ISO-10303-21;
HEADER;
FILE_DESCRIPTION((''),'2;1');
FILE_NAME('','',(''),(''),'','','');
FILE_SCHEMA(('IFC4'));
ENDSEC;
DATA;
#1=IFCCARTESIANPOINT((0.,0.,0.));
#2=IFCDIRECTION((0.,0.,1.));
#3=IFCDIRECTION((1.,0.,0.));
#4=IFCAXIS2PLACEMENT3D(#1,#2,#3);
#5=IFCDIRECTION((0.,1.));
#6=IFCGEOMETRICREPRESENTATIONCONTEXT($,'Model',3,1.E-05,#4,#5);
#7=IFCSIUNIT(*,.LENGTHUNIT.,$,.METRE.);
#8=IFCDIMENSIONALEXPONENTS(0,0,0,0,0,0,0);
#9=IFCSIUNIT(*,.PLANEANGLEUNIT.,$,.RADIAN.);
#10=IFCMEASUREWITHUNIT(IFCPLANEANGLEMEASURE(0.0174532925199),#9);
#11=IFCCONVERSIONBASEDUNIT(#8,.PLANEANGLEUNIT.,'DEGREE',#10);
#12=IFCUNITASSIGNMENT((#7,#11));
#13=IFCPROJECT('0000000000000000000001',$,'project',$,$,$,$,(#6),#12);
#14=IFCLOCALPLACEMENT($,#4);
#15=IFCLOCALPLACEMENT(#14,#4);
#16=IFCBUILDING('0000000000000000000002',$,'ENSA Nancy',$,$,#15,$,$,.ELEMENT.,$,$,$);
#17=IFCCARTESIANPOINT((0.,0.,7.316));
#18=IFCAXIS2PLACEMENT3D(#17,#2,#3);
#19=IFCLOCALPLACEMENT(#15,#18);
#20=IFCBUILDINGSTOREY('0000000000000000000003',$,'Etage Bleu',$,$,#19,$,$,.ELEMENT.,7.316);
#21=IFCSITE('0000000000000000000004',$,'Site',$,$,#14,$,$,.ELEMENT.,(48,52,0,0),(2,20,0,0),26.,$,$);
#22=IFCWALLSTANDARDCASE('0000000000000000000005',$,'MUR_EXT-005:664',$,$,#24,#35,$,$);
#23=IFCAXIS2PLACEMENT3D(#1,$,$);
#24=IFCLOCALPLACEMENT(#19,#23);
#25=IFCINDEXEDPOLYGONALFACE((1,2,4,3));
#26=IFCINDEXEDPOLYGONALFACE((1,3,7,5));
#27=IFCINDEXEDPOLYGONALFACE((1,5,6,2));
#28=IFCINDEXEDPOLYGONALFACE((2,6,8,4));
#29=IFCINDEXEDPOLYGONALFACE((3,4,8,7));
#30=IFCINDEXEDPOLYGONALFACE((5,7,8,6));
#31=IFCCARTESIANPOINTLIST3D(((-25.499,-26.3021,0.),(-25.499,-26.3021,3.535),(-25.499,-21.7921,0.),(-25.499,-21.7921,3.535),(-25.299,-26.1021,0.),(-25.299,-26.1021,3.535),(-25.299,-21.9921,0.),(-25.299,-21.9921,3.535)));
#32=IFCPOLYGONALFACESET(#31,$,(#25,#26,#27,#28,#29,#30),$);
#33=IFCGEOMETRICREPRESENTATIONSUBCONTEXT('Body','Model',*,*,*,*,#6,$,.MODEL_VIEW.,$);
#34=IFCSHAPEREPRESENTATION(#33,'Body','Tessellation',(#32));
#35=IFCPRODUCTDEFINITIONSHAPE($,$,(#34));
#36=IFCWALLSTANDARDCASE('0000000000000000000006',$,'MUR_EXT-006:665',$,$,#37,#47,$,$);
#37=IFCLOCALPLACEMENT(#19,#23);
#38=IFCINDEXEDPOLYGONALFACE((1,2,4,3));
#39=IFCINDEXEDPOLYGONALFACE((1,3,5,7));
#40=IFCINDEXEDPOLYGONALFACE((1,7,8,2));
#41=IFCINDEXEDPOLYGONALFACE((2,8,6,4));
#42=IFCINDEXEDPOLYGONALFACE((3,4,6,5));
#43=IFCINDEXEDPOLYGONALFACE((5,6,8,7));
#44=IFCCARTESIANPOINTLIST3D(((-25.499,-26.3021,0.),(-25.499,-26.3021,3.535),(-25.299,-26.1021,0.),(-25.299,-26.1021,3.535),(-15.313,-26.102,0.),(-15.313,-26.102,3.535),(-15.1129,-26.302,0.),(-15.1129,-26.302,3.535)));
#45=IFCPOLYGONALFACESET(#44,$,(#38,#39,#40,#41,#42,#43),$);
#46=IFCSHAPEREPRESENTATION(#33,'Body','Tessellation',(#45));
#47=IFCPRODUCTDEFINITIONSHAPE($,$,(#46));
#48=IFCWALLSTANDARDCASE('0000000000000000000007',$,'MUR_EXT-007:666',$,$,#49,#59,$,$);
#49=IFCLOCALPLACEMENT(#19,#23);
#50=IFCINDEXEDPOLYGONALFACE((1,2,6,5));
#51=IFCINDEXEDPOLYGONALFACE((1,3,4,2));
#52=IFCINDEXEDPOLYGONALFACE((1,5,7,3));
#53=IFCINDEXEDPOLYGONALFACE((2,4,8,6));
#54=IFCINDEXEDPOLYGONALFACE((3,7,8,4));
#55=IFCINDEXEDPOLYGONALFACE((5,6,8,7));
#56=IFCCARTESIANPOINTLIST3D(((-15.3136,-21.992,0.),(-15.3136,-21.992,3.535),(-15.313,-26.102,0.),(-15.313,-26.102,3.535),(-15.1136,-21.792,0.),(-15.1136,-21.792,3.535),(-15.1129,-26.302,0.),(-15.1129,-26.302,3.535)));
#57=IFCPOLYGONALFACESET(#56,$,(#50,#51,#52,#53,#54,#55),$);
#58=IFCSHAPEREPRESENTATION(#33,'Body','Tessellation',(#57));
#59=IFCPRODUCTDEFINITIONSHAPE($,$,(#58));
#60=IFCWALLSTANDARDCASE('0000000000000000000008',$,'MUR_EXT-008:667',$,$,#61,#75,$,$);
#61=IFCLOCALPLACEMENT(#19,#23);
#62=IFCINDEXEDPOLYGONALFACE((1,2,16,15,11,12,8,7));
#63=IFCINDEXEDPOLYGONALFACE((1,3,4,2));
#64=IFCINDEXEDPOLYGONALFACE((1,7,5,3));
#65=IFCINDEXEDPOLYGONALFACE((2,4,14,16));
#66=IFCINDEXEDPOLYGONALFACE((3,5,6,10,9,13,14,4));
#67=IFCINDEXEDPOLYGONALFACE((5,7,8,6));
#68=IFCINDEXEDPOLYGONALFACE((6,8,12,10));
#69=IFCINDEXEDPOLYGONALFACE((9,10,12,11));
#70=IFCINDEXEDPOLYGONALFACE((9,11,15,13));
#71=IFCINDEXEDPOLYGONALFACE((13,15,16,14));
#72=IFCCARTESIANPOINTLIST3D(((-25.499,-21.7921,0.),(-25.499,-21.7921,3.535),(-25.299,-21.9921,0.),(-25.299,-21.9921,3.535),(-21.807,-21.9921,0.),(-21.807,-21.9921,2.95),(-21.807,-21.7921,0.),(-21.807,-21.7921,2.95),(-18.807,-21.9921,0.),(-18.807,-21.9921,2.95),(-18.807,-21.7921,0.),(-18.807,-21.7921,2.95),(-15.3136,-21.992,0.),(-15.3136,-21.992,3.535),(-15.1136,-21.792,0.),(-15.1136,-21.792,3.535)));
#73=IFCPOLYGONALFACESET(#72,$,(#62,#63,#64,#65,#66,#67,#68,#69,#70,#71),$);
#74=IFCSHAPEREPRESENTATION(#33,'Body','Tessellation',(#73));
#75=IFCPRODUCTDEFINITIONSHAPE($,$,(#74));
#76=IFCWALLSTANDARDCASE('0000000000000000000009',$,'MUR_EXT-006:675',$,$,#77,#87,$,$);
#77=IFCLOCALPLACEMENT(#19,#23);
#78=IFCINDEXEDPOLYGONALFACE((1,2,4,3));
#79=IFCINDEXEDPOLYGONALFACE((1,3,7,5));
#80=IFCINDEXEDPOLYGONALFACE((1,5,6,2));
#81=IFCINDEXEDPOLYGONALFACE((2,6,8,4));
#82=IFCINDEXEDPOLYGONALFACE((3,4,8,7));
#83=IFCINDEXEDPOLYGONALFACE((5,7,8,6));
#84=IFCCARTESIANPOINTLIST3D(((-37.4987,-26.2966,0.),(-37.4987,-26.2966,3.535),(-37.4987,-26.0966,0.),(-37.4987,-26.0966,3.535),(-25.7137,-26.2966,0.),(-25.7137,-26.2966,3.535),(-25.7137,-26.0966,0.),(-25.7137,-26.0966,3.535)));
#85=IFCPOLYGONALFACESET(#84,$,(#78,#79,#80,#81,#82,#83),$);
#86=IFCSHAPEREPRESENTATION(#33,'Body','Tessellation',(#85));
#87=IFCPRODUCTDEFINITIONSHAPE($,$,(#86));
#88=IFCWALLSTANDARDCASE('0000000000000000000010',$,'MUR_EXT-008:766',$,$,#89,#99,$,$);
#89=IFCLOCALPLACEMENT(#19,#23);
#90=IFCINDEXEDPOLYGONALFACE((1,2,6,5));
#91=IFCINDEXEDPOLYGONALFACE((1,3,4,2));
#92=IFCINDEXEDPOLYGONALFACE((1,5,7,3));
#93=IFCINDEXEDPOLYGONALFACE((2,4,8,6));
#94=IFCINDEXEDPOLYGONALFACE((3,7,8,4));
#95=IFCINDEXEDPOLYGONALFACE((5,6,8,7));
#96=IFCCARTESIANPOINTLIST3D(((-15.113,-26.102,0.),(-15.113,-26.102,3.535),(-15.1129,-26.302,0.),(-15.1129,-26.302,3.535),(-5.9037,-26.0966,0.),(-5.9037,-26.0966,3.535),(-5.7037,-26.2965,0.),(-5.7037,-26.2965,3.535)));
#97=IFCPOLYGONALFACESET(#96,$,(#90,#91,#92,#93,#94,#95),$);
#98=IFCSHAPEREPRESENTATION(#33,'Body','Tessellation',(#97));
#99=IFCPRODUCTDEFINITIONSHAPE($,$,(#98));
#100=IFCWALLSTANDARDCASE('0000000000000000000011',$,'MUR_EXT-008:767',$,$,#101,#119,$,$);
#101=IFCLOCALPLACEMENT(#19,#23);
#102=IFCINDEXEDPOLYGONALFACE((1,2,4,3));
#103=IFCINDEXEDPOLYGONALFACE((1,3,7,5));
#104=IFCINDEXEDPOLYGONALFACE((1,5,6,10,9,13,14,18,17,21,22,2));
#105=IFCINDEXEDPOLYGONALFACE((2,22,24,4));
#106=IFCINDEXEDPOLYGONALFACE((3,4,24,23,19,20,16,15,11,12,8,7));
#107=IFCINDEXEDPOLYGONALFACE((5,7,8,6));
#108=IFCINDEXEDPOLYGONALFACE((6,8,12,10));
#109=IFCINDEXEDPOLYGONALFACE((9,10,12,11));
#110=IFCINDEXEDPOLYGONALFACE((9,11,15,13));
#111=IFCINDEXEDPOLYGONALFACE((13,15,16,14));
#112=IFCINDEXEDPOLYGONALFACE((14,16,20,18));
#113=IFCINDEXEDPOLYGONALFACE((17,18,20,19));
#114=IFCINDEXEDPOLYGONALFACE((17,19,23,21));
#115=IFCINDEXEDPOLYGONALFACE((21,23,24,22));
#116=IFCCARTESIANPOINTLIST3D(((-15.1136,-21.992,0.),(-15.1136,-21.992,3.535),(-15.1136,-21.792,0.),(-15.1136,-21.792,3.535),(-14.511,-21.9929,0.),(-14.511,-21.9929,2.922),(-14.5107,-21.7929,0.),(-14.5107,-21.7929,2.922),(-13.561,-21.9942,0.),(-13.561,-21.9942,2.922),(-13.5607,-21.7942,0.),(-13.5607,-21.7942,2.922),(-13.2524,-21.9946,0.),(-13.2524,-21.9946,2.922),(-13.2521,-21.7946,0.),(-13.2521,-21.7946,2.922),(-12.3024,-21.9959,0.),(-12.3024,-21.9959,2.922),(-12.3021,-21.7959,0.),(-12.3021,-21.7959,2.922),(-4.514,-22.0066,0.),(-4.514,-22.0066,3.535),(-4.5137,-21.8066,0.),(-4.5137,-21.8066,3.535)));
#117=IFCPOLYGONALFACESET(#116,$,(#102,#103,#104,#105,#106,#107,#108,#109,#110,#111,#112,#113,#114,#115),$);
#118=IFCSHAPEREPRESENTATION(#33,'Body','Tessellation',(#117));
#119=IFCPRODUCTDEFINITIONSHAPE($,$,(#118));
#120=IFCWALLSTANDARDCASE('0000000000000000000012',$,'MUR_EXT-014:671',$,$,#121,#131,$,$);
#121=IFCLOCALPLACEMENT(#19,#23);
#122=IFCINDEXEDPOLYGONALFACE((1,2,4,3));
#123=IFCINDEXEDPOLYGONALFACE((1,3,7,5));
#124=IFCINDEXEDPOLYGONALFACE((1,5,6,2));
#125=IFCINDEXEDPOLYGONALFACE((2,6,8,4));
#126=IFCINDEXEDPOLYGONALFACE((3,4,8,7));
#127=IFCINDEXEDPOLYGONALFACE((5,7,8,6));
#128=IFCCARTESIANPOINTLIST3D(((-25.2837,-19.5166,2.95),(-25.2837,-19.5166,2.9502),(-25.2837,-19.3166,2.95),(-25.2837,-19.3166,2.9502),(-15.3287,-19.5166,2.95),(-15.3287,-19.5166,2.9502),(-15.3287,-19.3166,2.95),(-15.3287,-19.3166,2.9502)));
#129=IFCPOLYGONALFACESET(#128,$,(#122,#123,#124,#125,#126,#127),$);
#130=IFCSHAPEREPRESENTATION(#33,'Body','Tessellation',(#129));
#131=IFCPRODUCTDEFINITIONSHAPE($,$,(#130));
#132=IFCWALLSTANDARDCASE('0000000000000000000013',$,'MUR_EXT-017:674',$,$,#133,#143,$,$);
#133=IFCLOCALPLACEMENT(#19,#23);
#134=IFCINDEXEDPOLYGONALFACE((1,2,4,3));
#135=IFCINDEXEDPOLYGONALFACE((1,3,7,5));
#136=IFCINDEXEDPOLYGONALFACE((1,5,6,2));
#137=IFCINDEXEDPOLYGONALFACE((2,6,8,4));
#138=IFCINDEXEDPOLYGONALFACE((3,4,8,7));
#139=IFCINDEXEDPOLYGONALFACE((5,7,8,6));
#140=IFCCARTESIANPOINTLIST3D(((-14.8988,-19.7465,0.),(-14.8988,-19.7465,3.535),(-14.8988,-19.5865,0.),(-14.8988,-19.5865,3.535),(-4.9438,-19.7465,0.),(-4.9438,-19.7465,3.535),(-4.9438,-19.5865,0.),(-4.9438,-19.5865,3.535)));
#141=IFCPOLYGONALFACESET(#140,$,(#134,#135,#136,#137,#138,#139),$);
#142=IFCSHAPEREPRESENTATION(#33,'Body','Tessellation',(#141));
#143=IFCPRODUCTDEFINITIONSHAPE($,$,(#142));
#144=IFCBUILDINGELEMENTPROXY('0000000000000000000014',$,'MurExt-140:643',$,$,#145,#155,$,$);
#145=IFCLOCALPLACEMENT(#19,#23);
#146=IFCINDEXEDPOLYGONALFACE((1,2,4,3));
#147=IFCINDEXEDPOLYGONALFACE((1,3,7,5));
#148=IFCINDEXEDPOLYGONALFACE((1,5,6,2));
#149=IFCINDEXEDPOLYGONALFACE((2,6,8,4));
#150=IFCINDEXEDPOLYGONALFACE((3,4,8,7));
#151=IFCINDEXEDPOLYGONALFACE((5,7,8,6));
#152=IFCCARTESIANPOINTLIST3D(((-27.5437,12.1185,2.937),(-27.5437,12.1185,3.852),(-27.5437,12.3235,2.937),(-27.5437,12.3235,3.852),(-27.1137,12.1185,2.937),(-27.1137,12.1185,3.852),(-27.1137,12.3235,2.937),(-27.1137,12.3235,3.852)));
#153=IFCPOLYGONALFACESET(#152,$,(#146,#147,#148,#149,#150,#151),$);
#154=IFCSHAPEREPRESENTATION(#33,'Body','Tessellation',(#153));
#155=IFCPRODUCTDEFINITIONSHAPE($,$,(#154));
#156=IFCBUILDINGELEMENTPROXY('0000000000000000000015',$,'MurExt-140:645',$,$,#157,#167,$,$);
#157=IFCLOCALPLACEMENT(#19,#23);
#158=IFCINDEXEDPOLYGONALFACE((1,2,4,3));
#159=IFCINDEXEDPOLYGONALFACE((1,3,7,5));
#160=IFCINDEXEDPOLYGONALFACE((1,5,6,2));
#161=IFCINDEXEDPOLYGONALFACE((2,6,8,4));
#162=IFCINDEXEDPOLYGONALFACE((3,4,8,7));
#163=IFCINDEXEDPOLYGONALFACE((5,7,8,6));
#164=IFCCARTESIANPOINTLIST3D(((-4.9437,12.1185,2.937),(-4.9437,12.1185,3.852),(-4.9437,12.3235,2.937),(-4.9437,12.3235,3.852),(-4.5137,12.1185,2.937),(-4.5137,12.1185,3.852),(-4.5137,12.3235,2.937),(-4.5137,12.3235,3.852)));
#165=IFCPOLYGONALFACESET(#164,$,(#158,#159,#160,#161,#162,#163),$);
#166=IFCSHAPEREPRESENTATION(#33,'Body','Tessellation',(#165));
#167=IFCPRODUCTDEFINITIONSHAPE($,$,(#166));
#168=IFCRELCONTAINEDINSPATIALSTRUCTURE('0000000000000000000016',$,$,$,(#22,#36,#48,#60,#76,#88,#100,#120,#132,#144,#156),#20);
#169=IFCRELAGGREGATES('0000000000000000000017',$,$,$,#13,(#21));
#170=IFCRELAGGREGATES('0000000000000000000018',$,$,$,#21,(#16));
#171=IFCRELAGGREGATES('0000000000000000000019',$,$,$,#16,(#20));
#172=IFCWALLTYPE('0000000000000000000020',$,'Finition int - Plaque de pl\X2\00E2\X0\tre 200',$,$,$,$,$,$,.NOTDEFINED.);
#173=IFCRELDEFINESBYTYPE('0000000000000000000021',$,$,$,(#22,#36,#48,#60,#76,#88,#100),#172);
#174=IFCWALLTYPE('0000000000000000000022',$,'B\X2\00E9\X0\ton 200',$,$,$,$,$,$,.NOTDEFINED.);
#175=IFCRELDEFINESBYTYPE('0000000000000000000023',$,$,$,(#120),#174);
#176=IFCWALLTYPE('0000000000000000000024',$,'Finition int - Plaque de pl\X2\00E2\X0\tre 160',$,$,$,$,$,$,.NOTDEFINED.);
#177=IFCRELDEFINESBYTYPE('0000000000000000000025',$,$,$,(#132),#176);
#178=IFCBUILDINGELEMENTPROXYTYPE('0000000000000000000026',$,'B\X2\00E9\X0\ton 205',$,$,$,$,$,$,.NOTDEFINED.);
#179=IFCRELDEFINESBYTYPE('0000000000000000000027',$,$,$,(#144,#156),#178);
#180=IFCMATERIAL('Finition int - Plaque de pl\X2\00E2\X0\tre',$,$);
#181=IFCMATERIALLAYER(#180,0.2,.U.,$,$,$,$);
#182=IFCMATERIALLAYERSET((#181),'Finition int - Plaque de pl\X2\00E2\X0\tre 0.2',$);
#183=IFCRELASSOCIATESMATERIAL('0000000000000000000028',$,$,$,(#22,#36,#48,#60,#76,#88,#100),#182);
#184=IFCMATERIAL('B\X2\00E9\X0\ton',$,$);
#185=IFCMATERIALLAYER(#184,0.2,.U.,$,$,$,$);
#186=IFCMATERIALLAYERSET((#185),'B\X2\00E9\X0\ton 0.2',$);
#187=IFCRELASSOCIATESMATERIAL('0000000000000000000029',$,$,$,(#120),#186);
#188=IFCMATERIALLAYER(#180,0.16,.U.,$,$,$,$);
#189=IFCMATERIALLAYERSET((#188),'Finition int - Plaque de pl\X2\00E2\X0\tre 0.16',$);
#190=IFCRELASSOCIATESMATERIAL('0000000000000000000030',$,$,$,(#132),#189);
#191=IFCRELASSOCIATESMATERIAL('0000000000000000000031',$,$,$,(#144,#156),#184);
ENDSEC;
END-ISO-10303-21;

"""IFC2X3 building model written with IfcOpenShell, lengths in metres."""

from ifc_helpers import new_model, entity, si_unit, converted_unit, direction, frame, origin_with_axes, origin_2d_with_axis, place, context, subcontext, project, spatial, polyline, rectangle, outline, extrude, material, layer, layer_set, layer_usage, type_object, element, save


model = new_model("IFC2X3")

# Units and contexts
model_context = context("Model", 3, precision=1e-05, world=origin_with_axes(), true_north=direction((0.0, 1.0)))
body_context = subcontext(model_context, "Body", "Model", "MODEL_VIEW")
ifc_project = project(units=[si_unit("LENGTHUNIT", "METRE"), converted_unit("PLANEANGLEUNIT", "DEGREE", entity("IfcPlaneAngleMeasure", 0.0174532925199), si_unit("PLANEANGLEUNIT", "RADIAN"), dimensions=[0, 0, 0, 0, 0, 0, 0])], contexts=[model_context])

# Site, building, storey
site_placement = place(None, origin_with_axes())
site = spatial("IfcSite", under=ifc_project, at=site_placement, Name="Site", CompositionType="ELEMENT", RefLatitude=(48, 52, 0, 0), RefLongitude=(2, 20, 0, 0), RefElevation=26.0)
building_placement = place(site_placement, origin_with_axes())
building = spatial("IfcBuilding", under=site, at=building_placement, Name="ENSA Nancy", CompositionType="ELEMENT")
storey_placement = place(building_placement, frame((0.0, 0.0, 7.316), z_axis=(0.0, 0.0, 1.0), x_axis=(1.0, 0.0, 0.0)))
storey = spatial("IfcBuildingStorey", under=building, at=storey_placement, Name="Etage Bleu", CompositionType="ELEMENT", Elevation=7.316)

# Walls
ifc_material_1 = material(Name="Finition int - Plaque de plâtre")
ifc_layer_1 = layer(ifc_material_1, 0.2, ventilated="UNKNOWN")
ifc_layer_set_1 = layer_set([ifc_layer_1], Name="Finition int - Plaque de plâtre 0.2")
ifc_layer_usage_1 = layer_usage(ifc_layer_set_1, "AXIS2", "POSITIVE", 0.0)
wall_type_1 = type_object("IfcWallType", Name="Finition int - Plaque de plâtre 200", PredefinedType="NOTDEFINED")
wall_1_placement = place(storey_placement, frame((-25.499, -21.7921, 0.0), z_axis=(0.0, 0.0, 1.0), x_axis=(0.0, -1.0, 0.0)))
element("IfcWallStandardCase", 1, at=wall_1_placement, inside=storey, type_object=wall_type_1, material=ifc_layer_usage_1, Name="MUR_EXT-005:664", context=body_context, shape_type="SweptSolid", body=[
    extrude(outline(polyline([(0.0, 0.0), (4.51, 0.0), (4.31, 0.2), (0.2, 0.2), (0.0, 0.0)])), origin_with_axes(), (0.0, 0.0, 1.0), 3.535),
])
ifc_layer_usage_2 = layer_usage(ifc_layer_set_1, "AXIS2", "POSITIVE", 0.0)
wall_2_placement = place(storey_placement, frame((-25.499, -26.3021, 0.0), z_axis=(0.0, 0.0, 1.0), x_axis=(1.0, 0.000003, 0.0)))
element("IfcWallStandardCase", 2, at=wall_2_placement, inside=storey, type_object=wall_type_1, material=ifc_layer_usage_2, Name="MUR_EXT-006:665", context=body_context, shape_type="SweptSolid", body=[
    extrude(outline(polyline([(0.0, 0.0), (10.386, 0.0), (10.186, 0.2), (0.2, 0.2), (0.0, 0.0)])), origin_with_axes(), (0.0, 0.0, 1.0), 3.535),
])
ifc_layer_usage_3 = layer_usage(ifc_layer_set_1, "AXIS2", "POSITIVE", 0.0)
wall_3_placement = place(storey_placement, frame((-15.1129, -26.302, 0.0), z_axis=(0.0, 0.0, 1.0), x_axis=(-0.00015, 1.0, 0.0)))
element("IfcWallStandardCase", 3, at=wall_3_placement, inside=storey, type_object=wall_type_1, material=ifc_layer_usage_3, Name="MUR_EXT-007:666", context=body_context, shape_type="SweptSolid", body=[
    extrude(outline(polyline([(0.0, 0.0), (4.51, 0.0), (4.31, 0.2), (0.2, 0.2), (0.0, 0.0)])), origin_with_axes(), (0.0, 0.0, 1.0), 3.535),
])

# Wall, opening
ifc_layer_usage_4 = layer_usage(ifc_layer_set_1, "AXIS2", "POSITIVE", 0.0)
wall_4_placement = place(storey_placement, frame((-15.1136, -21.792, 0.0), z_axis=(0.0, 0.0, 1.0), x_axis=(-1.0, -0.000003, 0.0)))
wall_4 = element("IfcWallStandardCase", 4, at=wall_4_placement, inside=storey, type_object=wall_type_1, material=ifc_layer_usage_4, Name="MUR_EXT-008:667", context=body_context, shape_type="SweptSolid", body=[
    extrude(outline(polyline([(0.0, 0.0), (10.3854, 0.0), (10.1854, 0.2), (0.2, 0.2), (0.0, 0.0)])), origin_with_axes(), (0.0, 0.0, 1.0), 3.535),
])
opening_1_placement = place(wall_4_placement, frame((5.1934, 0.0, 0.0), z_axis=(0.0, 0.0, 1.0), x_axis=(1.0, 0.0, 0.0)))
element("IfcOpeningElement", 5, at=opening_1_placement, cuts=wall_4, context=body_context, shape_type="SweptSolid", body=[
    extrude(rectangle(XDim=3.0, YDim=2.95, at=origin_2d_with_axis()), frame((0.0, 0.2, 1.475), z_axis=(0.0, 1.0, 0.0), x_axis=(-1.0, 0.0, 0.0)), (0.0, 0.0, -1.0), 0.6),
])

# Walls
ifc_layer_usage_5 = layer_usage(ifc_layer_set_1, "AXIS2", "POSITIVE", 0.0)
wall_5_placement = place(storey_placement, frame((-37.4987, -26.2966, 0.0), z_axis=(0.0, 0.0, 1.0), x_axis=(1.0, 0.0, 0.0)))
element("IfcWallStandardCase", 6, at=wall_5_placement, inside=storey, type_object=wall_type_1, material=ifc_layer_usage_5, Name="MUR_EXT-006:675", context=body_context, shape_type="SweptSolid", body=[
    extrude(outline(polyline([(0.0, 0.0), (11.785, 0.0), (11.785, 0.2), (0.0, 0.2), (0.0, 0.0)])), origin_with_axes(), (0.0, 0.0, 1.0), 3.535),
])
ifc_layer_usage_6 = layer_usage(ifc_layer_set_1, "AXIS2", "NEGATIVE", 0.0)
wall_6_placement = place(storey_placement, frame((-5.7037, -26.2965, 0.0), z_axis=(0.0, 0.0, 1.0), x_axis=(-1.0, -0.000589, 0.0)))
element("IfcWallStandardCase", 7, at=wall_6_placement, inside=storey, type_object=wall_type_1, material=ifc_layer_usage_6, Name="MUR_EXT-008:766", context=body_context, shape_type="SweptSolid", body=[
    extrude(outline(polyline([(0.1999, -0.2), (9.4092, -0.2), (9.4092, 0.0), (0.0, 0.0), (0.1999, -0.2)])), origin_with_axes(), (0.0, 0.0, 1.0), 3.535),
])

# Wall, openings
ifc_layer_usage_7 = layer_usage(ifc_layer_set_1, "AXIS2", "POSITIVE", 0.0)
wall_7_placement = place(storey_placement, frame((-4.5137, -21.8066, 0.0), z_axis=(0.0, 0.0, 1.0), x_axis=(-0.999999, 0.001372, 0.0)))
wall_7 = element("IfcWallStandardCase", 8, at=wall_7_placement, inside=storey, type_object=wall_type_1, material=ifc_layer_usage_7, Name="MUR_EXT-008:767", context=body_context, shape_type="SweptSolid", body=[
    extrude(outline(polyline([(0.0, 0.0), (10.5999, 0.0), (10.5996, 0.2), (0.0, 0.2), (0.0, 0.0)])), origin_with_axes(), (0.0, 0.0, 1.0), 3.535),
])
opening_2_placement = place(wall_7_placement, frame((8.2634, 0.0, 0.0), z_axis=(0.0, 0.0, 1.0), x_axis=(1.0, 0.0, 0.0)))
element("IfcOpeningElement", 9, at=opening_2_placement, cuts=wall_7, context=body_context, shape_type="SweptSolid", body=[
    extrude(rectangle(XDim=0.95, YDim=2.922, at=origin_2d_with_axis()), frame((0.0, 0.2, 1.461), z_axis=(0.0, 1.0, 0.0), x_axis=(1.0, 0.0, 0.0)), (0.0, 0.0, -1.0), 0.6),
])
opening_3_placement = place(wall_7_placement, frame((9.522, 0.0, 0.0), z_axis=(0.0, 0.0, 1.0), x_axis=(1.0, 0.0, 0.0)))
element("IfcOpeningElement", 10, at=opening_3_placement, cuts=wall_7, context=body_context, shape_type="SweptSolid", body=[
    extrude(rectangle(XDim=0.95, YDim=2.922, at=origin_2d_with_axis()), frame((0.0, 0.2, 1.461), z_axis=(0.0, -1.0, 0.0), x_axis=(-1.0, 0.0, 0.0)), (0.0, 0.0, 1.0), 0.6),
])

# Wall, opening
ifc_material_2 = material(Name="Béton")
ifc_layer_2 = layer(ifc_material_2, 0.2, ventilated="UNKNOWN")
ifc_layer_set_2 = layer_set([ifc_layer_2], Name="Béton 0.2")
ifc_layer_usage_8 = layer_usage(ifc_layer_set_2, "AXIS2", "POSITIVE", -0.2)
wall_type_2 = type_object("IfcWallType", Name="Béton 200", PredefinedType="NOTDEFINED")
wall_8_placement = place(storey_placement, frame((-25.2837, -19.3166, 0.0), z_axis=(0.0, 0.0, 1.0), x_axis=(1.0, 0.0, 0.0)))
wall_8 = element("IfcWallStandardCase", 11, at=wall_8_placement, inside=storey, type_object=wall_type_2, material=ifc_layer_usage_8, Name="MUR_EXT-014:671", context=body_context, shape_type="SweptSolid", body=[
    extrude(outline(polyline([(0.0, -0.2), (9.955, -0.2), (9.955, 0.0), (0.0, 0.0), (0.0, -0.2)])), origin_with_axes(), (0.0, 0.0, 1.0), 2.9502),
])
opening_4_placement = place(wall_8_placement, frame((4.9775, 0.0, 0.0), z_axis=(0.0, 0.0, 1.0), x_axis=(1.0, 0.0, 0.0)))
element("IfcOpeningElement", 12, at=opening_4_placement, cuts=wall_8, context=body_context, shape_type="SweptSolid", body=[
    extrude(rectangle(XDim=9.955, YDim=2.95, at=origin_2d_with_axis()), frame((0.0, -0.2, 1.475), z_axis=(0.0, -1.0, 0.0), x_axis=(1.0, 0.0, 0.0)), (0.0, 0.0, -1.0), 0.6),
])

# Wall
ifc_layer_3 = layer(ifc_material_1, 0.16, ventilated="UNKNOWN")
ifc_layer_set_3 = layer_set([ifc_layer_3], Name="Finition int - Plaque de plâtre 0.16")
ifc_layer_usage_9 = layer_usage(ifc_layer_set_3, "AXIS2", "POSITIVE", -0.16)
wall_type_3 = type_object("IfcWallType", Name="Finition int - Plaque de plâtre 160", PredefinedType="NOTDEFINED")
wall_9_placement = place(storey_placement, frame((-14.8988, -19.5865, 0.0), z_axis=(0.0, 0.0, 1.0), x_axis=(1.0, 0.0, 0.0)))
element("IfcWallStandardCase", 13, at=wall_9_placement, inside=storey, type_object=wall_type_3, material=ifc_layer_usage_9, Name="MUR_EXT-017:674", context=body_context, shape_type="SweptSolid", body=[
    extrude(outline(polyline([(0.0, -0.16), (9.955, -0.16), (9.955, 0.0), (0.0, 0.0), (0.0, -0.16)])), origin_with_axes(), (0.0, 0.0, 1.0), 3.535),
])

# Building element proxies
building_element_proxy_type_1 = type_object("IfcBuildingElementProxyType", Name="Béton 205", PredefinedType="NOTDEFINED")
for number, where, z_axis, x_axis, name in (
    (14, (-27.5437, 12.3235, 2.937), (0.0, 0.0, 1.0), (1.0, 0.0, 0.0), "MurExt-140:643"),
    (15, (-4.9437, 12.3235, 2.937), (0.0, 0.0, 1.0), (1.0, 0.0, 0.0), "MurExt-140:645"),
):
    element("IfcBuildingElementProxy", number, at=place(storey_placement, frame(where, z_axis=z_axis, x_axis=x_axis)), inside=storey, type_object=building_element_proxy_type_1, material=ifc_material_2, Name=name, context=body_context, shape_type="SweptSolid", body=[
        extrude(outline(polyline([(0.0, -0.205), (0.43, -0.205), (0.43, 0.0), (0.0, 0.0), (0.0, -0.205)])), origin_with_axes(), (0.0, 0.0, 1.0), 0.915),
    ])

save(model, "model.ifc")
